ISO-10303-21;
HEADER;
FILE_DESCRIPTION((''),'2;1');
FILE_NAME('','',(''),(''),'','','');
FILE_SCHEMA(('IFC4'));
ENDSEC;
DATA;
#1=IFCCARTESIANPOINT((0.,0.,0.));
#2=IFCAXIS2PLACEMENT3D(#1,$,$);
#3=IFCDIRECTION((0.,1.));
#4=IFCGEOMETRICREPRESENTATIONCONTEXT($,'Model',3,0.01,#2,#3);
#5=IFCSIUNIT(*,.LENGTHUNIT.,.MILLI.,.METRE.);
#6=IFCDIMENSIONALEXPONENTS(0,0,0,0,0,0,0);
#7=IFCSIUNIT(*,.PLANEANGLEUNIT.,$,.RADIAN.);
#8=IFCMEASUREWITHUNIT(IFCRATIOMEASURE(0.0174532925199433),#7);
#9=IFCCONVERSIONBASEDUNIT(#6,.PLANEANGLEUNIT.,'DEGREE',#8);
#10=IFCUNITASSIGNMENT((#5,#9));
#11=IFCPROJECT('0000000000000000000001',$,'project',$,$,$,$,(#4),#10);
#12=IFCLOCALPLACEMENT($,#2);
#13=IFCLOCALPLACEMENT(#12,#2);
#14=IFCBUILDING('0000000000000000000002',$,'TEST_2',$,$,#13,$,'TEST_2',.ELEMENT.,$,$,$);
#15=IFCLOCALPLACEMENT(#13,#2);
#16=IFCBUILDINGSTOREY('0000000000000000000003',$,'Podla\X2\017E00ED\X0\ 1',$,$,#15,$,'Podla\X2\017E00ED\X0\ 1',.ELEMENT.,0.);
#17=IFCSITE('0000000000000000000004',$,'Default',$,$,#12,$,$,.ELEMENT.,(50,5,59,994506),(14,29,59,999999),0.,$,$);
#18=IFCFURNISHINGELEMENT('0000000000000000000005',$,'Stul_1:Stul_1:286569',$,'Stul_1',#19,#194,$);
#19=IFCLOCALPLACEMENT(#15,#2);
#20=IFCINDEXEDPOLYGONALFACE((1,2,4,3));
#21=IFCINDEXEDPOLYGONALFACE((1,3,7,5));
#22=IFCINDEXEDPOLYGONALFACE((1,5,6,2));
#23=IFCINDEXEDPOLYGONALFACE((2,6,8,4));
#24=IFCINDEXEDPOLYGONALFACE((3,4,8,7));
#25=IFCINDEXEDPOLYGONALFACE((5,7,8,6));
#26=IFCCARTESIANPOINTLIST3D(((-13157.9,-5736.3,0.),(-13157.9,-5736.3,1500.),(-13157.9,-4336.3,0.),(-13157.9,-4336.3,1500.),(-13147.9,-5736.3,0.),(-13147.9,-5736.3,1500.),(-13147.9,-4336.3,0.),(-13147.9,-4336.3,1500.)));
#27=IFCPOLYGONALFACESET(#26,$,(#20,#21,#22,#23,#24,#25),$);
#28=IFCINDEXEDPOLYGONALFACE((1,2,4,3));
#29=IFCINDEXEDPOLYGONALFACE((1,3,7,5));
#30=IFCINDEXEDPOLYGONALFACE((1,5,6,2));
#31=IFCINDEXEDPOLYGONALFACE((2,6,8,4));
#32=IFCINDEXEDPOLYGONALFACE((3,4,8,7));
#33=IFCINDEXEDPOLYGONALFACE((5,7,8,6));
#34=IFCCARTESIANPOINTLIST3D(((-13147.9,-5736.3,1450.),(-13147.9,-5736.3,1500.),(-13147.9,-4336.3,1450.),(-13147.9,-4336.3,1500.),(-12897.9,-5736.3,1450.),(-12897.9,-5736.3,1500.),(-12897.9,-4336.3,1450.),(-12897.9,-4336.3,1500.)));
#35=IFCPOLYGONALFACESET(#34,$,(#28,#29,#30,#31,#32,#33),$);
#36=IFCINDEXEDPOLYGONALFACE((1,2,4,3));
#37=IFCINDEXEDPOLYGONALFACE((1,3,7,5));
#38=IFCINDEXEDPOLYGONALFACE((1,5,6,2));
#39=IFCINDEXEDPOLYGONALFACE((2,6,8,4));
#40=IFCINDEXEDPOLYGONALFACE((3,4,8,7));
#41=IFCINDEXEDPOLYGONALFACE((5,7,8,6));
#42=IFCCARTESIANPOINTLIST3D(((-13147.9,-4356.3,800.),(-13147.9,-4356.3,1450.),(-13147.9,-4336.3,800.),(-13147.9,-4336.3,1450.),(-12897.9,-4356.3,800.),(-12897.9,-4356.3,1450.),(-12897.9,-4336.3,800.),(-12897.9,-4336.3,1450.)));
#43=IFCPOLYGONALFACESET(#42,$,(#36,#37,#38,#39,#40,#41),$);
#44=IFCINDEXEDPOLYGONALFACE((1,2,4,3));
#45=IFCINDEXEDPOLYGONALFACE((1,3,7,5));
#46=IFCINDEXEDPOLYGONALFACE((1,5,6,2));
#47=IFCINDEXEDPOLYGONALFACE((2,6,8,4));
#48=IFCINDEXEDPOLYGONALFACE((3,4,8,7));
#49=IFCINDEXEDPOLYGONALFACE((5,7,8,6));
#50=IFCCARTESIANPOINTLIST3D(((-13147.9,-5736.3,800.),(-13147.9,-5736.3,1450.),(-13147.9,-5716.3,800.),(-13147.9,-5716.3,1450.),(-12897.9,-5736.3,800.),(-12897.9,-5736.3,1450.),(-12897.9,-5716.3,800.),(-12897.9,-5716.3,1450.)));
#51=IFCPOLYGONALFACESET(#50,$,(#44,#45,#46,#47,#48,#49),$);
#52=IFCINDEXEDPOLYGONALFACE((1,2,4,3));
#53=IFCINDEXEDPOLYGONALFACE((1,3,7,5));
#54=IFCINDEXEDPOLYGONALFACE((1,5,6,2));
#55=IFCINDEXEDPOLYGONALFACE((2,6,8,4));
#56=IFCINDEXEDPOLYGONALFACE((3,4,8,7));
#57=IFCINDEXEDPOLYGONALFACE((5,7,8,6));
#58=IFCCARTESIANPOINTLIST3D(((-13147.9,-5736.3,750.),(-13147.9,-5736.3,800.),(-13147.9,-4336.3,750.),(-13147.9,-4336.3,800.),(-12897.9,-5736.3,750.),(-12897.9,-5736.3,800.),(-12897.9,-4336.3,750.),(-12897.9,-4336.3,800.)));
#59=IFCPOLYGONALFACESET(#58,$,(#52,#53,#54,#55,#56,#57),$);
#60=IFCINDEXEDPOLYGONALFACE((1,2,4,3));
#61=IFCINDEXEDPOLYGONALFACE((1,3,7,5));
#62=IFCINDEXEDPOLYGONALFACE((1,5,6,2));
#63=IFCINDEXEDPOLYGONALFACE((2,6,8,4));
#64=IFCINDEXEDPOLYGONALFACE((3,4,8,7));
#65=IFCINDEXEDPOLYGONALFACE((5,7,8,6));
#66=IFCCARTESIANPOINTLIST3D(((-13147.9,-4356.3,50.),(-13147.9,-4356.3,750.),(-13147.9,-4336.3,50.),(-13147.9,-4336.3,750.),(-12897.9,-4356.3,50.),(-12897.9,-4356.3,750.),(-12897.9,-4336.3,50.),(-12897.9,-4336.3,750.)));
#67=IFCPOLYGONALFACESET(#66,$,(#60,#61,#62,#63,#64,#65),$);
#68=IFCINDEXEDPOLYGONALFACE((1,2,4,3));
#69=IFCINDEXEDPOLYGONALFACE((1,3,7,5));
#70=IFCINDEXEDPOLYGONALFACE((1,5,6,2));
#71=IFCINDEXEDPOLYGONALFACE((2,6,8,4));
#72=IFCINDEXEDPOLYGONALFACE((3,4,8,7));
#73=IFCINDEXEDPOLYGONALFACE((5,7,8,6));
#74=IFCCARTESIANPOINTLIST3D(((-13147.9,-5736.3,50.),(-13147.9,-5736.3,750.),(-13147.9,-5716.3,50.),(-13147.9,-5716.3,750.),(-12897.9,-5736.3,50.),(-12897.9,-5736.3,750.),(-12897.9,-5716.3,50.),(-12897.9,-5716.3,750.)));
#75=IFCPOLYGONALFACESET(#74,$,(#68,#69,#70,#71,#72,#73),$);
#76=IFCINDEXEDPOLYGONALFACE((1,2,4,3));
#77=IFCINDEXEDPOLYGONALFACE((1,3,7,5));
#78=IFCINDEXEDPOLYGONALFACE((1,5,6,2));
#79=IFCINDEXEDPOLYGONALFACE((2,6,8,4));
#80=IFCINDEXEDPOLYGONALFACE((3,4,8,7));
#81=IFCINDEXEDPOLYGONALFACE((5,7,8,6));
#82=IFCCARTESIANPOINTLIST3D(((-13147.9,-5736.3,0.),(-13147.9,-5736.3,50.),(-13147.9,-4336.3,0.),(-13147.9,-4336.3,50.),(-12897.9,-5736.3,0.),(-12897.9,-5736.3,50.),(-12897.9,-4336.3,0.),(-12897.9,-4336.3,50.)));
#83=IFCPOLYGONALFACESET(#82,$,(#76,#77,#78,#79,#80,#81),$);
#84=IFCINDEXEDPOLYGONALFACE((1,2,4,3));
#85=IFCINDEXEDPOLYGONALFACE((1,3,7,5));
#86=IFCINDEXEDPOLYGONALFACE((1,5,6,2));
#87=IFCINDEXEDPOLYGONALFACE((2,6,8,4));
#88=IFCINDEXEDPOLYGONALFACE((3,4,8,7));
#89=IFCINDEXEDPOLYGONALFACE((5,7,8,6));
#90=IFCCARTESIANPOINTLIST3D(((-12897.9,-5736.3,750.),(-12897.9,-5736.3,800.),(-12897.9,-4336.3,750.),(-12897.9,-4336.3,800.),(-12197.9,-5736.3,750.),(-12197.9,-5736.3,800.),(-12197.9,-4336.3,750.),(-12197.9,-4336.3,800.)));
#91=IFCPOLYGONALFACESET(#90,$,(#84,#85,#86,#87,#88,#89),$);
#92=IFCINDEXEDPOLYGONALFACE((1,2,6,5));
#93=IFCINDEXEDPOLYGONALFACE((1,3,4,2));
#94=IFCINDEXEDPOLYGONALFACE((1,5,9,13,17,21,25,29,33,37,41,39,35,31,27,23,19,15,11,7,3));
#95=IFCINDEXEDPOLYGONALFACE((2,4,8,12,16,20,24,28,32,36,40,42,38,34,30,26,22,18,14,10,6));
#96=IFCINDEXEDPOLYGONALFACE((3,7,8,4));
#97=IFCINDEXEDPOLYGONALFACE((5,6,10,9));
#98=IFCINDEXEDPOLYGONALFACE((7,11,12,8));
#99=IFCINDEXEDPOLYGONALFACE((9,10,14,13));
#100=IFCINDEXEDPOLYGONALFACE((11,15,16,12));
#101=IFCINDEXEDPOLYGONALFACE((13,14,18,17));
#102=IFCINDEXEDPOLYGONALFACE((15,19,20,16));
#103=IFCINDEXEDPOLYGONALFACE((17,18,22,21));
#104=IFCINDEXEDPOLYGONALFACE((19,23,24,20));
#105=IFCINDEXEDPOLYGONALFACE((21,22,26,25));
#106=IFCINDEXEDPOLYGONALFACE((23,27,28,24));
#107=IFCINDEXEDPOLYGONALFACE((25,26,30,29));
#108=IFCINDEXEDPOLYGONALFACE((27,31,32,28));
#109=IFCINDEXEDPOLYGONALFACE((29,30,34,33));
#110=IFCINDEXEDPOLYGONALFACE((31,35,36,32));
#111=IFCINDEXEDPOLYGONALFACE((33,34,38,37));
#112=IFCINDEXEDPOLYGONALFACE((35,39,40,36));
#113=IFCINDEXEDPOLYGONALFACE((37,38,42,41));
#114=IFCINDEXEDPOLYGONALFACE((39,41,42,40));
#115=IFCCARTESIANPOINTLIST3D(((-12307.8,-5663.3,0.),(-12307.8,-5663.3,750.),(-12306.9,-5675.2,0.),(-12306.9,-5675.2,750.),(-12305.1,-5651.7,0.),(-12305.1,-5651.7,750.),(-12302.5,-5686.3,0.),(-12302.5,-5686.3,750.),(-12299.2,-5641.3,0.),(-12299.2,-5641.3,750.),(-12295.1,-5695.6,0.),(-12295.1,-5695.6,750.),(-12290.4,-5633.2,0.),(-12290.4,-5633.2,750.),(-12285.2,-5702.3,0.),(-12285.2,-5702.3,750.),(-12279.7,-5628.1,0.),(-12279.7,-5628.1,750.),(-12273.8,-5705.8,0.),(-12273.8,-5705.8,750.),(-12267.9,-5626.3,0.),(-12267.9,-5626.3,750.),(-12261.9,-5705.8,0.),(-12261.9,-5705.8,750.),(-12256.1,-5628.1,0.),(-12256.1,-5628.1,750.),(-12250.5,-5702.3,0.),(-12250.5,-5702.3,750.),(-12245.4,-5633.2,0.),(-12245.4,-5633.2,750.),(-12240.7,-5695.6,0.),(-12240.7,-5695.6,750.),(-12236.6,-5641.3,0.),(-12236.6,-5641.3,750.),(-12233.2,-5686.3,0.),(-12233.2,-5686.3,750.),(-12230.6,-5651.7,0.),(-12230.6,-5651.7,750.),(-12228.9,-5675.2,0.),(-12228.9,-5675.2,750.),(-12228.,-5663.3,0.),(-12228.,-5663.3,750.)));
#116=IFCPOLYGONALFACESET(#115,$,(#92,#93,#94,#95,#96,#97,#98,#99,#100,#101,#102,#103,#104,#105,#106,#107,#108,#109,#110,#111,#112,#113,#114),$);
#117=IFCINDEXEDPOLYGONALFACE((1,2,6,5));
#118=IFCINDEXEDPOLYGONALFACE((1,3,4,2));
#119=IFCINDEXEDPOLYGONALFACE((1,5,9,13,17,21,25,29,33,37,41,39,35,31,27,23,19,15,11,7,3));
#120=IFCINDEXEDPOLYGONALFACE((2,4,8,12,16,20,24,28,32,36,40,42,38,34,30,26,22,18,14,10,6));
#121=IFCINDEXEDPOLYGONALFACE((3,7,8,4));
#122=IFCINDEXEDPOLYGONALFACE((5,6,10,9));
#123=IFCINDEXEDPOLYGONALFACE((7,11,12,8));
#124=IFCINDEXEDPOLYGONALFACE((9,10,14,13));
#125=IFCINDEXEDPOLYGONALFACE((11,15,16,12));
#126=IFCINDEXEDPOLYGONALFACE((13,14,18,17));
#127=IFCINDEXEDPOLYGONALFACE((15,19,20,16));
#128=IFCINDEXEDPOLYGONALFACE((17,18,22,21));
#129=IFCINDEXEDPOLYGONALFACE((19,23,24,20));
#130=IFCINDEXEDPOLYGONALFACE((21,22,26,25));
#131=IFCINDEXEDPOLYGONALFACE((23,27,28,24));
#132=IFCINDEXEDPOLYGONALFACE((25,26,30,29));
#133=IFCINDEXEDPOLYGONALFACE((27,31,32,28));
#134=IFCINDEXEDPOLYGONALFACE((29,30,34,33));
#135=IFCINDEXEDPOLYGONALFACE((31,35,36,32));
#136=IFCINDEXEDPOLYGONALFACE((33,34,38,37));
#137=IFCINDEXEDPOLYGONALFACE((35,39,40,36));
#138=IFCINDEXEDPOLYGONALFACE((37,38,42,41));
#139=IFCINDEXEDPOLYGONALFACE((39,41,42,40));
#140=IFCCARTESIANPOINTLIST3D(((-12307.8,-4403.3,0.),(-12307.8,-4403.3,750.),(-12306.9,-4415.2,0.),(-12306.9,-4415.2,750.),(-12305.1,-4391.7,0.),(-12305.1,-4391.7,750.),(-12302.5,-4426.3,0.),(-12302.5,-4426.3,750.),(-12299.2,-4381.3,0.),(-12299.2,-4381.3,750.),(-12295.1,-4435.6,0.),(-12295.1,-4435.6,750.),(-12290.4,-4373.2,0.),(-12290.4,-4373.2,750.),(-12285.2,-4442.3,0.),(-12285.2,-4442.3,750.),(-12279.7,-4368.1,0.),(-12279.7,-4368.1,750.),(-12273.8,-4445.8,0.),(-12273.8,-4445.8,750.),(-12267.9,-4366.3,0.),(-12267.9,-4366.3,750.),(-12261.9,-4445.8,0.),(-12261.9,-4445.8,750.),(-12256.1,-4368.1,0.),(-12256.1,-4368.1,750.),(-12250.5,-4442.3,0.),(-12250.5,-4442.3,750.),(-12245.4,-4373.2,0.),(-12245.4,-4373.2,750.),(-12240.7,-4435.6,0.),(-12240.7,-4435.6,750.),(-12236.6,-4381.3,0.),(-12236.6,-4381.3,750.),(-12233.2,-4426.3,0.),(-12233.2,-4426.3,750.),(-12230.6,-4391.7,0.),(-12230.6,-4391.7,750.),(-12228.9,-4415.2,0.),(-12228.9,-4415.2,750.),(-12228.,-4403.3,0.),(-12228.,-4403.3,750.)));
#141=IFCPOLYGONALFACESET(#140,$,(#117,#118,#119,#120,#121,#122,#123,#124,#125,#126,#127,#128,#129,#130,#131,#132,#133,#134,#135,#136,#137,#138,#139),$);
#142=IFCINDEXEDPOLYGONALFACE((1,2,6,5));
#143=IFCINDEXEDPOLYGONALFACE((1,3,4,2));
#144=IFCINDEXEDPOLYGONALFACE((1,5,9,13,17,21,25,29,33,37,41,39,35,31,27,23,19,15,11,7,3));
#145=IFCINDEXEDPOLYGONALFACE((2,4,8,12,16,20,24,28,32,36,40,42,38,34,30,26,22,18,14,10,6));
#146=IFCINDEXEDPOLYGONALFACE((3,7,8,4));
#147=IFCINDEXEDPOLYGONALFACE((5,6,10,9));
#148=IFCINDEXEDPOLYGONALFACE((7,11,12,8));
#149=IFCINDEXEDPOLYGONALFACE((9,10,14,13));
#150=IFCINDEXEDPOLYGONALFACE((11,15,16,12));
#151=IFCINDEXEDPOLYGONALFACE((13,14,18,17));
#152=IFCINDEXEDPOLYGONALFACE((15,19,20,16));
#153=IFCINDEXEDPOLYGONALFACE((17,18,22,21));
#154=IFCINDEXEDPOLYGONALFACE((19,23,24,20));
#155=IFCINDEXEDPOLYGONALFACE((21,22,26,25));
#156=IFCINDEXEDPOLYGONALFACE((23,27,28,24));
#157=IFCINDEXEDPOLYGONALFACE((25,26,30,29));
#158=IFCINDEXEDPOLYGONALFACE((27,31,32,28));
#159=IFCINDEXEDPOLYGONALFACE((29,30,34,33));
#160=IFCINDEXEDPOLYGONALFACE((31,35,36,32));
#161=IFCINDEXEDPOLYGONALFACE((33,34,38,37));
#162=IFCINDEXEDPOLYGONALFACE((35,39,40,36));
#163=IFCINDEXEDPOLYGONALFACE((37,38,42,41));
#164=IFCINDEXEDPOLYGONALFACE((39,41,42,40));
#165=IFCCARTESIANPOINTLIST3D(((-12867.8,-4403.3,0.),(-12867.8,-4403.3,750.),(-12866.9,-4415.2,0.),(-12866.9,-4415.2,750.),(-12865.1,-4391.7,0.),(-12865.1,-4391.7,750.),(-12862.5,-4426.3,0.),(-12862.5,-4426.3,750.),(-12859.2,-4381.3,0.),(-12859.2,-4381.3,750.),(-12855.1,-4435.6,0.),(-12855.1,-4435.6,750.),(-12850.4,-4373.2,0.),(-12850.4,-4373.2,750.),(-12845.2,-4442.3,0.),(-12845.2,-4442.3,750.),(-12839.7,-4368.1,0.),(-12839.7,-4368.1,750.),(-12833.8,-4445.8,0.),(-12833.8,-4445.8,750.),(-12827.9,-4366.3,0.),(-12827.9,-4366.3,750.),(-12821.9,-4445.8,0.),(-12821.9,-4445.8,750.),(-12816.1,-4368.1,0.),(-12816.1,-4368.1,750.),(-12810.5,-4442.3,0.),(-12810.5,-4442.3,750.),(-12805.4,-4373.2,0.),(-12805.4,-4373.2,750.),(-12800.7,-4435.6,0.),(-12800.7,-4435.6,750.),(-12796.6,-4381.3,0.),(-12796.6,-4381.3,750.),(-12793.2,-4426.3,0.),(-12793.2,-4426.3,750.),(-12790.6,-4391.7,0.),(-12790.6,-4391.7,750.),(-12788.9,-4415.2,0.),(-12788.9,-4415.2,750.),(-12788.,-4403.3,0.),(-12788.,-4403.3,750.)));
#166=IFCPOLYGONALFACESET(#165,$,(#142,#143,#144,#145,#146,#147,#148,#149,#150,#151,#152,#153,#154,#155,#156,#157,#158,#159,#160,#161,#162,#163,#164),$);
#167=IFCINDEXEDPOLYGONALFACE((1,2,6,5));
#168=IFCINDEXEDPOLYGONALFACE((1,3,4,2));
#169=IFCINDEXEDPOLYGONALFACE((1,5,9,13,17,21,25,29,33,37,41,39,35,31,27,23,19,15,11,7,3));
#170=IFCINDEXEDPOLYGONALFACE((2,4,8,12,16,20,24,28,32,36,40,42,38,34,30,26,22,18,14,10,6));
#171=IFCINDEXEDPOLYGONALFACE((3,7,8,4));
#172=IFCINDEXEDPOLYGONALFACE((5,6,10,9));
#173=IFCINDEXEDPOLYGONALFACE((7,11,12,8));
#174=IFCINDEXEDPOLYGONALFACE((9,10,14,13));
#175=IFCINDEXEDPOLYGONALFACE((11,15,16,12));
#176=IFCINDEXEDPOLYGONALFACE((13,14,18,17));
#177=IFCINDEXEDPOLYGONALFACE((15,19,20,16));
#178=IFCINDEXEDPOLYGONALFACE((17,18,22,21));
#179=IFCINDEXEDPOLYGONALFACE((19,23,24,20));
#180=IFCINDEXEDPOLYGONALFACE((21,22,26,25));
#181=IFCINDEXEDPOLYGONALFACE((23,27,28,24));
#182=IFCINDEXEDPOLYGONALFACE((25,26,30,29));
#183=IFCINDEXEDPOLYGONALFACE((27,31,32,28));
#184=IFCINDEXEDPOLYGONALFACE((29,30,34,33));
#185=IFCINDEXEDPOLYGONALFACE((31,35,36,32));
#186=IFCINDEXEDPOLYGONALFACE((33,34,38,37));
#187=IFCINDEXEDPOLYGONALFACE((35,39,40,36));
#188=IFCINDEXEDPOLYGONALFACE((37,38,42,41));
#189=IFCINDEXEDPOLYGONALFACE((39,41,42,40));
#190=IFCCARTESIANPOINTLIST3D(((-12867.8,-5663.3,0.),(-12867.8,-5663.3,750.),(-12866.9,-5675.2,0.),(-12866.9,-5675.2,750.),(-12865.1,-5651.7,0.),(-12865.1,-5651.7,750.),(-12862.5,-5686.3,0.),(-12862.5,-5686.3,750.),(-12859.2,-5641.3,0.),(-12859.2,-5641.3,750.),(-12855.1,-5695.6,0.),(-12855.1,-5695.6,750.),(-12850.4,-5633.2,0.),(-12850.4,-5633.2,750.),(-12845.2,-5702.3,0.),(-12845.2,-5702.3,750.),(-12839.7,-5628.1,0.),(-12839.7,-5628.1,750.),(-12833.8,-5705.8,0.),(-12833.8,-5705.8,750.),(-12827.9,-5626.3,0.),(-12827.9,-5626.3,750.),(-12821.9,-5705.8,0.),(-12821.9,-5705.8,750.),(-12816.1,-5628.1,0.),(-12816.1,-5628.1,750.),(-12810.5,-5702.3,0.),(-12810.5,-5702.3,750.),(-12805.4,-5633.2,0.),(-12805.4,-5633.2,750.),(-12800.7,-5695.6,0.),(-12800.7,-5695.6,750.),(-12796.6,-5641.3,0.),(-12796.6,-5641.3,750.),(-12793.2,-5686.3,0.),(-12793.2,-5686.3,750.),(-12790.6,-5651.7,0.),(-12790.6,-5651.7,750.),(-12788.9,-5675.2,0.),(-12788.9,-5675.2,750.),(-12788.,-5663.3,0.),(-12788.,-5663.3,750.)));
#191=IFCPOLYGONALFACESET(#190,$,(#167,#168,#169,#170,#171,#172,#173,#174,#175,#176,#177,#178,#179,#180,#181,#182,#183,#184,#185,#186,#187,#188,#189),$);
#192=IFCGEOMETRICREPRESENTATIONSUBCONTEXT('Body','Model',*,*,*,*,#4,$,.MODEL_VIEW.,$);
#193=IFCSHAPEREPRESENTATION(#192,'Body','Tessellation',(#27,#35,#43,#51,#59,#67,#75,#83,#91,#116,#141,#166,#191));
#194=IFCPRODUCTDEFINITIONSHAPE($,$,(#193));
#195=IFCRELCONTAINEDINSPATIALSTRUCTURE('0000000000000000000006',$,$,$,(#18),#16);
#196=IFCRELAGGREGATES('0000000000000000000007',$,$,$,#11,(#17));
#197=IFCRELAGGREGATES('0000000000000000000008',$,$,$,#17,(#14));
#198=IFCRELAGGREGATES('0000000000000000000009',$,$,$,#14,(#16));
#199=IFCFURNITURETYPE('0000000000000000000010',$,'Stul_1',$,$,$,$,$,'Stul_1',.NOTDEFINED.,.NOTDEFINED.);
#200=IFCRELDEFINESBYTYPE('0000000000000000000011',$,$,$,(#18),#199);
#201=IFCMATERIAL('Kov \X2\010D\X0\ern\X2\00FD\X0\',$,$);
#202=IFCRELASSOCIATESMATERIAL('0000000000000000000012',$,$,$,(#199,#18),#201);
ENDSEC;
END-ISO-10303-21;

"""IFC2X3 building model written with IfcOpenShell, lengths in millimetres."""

from ifc_helpers import new_model, entity, si_unit, converted_unit, direction, frame, frame_2d, origin, origin_2d_with_axis, place, context, subcontext, project, spatial, rectangle, circle, extrude, source, transform, mapped, material, type_object, type_shapes, element, save


model = new_model("IFC2X3")

# Units and contexts
model_context = context("Model", 3, precision=0.01, world=origin(), true_north=direction((0.0, 1.0)))
body_context = subcontext(model_context, "Body", "Model", "MODEL_VIEW")
ifc_project = project(units=[si_unit("LENGTHUNIT", "METRE", prefix="MILLI"), converted_unit("PLANEANGLEUNIT", "DEGREE", entity("IfcRatioMeasure", 0.0174532925199433), si_unit("PLANEANGLEUNIT", "RADIAN"), dimensions=[0, 0, 0, 0, 0, 0, 0])], contexts=[model_context])

# Site, building, storey
site_placement = place(None, origin())
site = spatial("IfcSite", under=ifc_project, at=site_placement, Name="Default", CompositionType="ELEMENT", RefLatitude=(50, 5, 59, 994506), RefLongitude=(14, 29, 59, 999999), RefElevation=0.0)
building_placement = place(site_placement, origin())
building = spatial("IfcBuilding", under=site, at=building_placement, Name="TEST_2", LongName="TEST_2", CompositionType="ELEMENT")
storey_placement = place(building_placement, origin())
storey = spatial("IfcBuildingStorey", under=building, at=storey_placement, Name="Podlaží 1", LongName="Podlaží 1", CompositionType="ELEMENT", Elevation=0.0)

# Furnishing element
ifc_material_1 = material(Name="Kov černý")
furniture_type = type_object("IfcFurnitureType", Name="Stul_1", ElementType="Stul_1", material=ifc_material_1)
shared_shape_1 = source(origin(), body_context, "Body", "SweptSolid", [
    extrude(rectangle(XDim=1400.0, YDim=10.0, at=origin_2d_with_axis()), frame((0.0, 605.0, 0.0), z_axis=(0.0, 0.0, 1.0), x_axis=(-1.0, 0.0, 0.0)), (0.0, 0.0, 1.0), 1500.0),
    extrude(rectangle(XDim=1400.0, YDim=250.0, at=frame_2d((0.0, 0.0), x_axis=(1.0, 0.0))), frame((0.0, 475.0, 1450.0), z_axis=(0.0, 0.0, 1.0), x_axis=(-1.0, 0.0, 0.0)), (0.0, 0.0, 1.0), 50.0),
    extrude(rectangle(XDim=20.0, YDim=250.0, at=origin_2d_with_axis()), frame((690.0, 475.0, 800.0), z_axis=(0.0, 0.0, 1.0), x_axis=(-1.0, 0.0, 0.0)), (0.0, 0.0, 1.0), 650.0),
    extrude(rectangle(XDim=20.0, YDim=250.0, at=frame_2d((0.0, 0.0), x_axis=(1.0, 0.0))), frame((-690.0, 475.0, 800.0), z_axis=(0.0, 0.0, 1.0), x_axis=(-1.0, 0.0, 0.0)), (0.0, 0.0, 1.0), 650.0),
    extrude(rectangle(XDim=1400.0, YDim=250.0, at=origin_2d_with_axis()), frame((0.0, 475.0, 750.0), z_axis=(0.0, 0.0, 1.0), x_axis=(-1.0, 0.0, 0.0)), (0.0, 0.0, 1.0), 50.0),
    extrude(rectangle(XDim=20.0, YDim=250.0, at=origin_2d_with_axis()), frame((690.0, 475.0, 50.0), z_axis=(0.0, 0.0, 1.0), x_axis=(-1.0, 0.0, 0.0)), (0.0, 0.0, 1.0), 700.0),
    extrude(rectangle(XDim=20.0, YDim=250.0, at=frame_2d((0.0, 0.0), x_axis=(1.0, 0.0))), frame((-690.0, 475.0, 50.0), z_axis=(0.0, 0.0, 1.0), x_axis=(-1.0, 0.0, 0.0)), (0.0, 0.0, 1.0), 700.0),
    extrude(rectangle(XDim=1400.0, YDim=250.0, at=origin_2d_with_axis()), frame((0.0, 475.0, 0.0), z_axis=(0.0, 0.0, 1.0), x_axis=(-1.0, 0.0, 0.0)), (0.0, 0.0, 1.0), 50.0),
    extrude(rectangle(XDim=1400.0, YDim=700.0, at=origin_2d_with_axis()), frame((0.0, 0.0, 750.0), z_axis=(0.0, 0.0, 1.0), x_axis=(-1.0, 0.0, 0.0)), (0.0, 0.0, 1.0), 50.0),
    extrude(circle(Radius=40.0, at=frame_2d((0.0, 0.0), x_axis=(1.0, 0.0))), frame((-630.0, -280.0, 0.0)), (0.0, 0.0, 1.0), 750.0),
    extrude(circle(Radius=40.0, at=frame_2d((0.0, 0.0), x_axis=(1.0, 0.0))), frame((630.0, -280.0, 0.0)), (0.0, 0.0, 1.0), 750.0),
    extrude(circle(Radius=40.0, at=frame_2d((0.0, 0.0), x_axis=(1.0, 0.0))), frame((630.0, 280.0, 0.0)), (0.0, 0.0, 1.0), 750.0),
    extrude(circle(Radius=40.0, at=frame_2d((0.0, 0.0), x_axis=(1.0, 0.0))), frame((-630.0, 280.0, 0.0)), (0.0, 0.0, 1.0), 750.0),
])
type_shapes(furniture_type, [shared_shape_1])
for number, where, z_axis, x_axis, name in (
    (1, (-12547.9, -5036.3, 0.0), (0.0, 0.0, 1.0), (0.0, 1.0, 0.0), "Stul_1:Stul_1:286569"),
):
    element("IfcFurnishingElement", number, at=place(storey_placement, frame(where, z_axis=z_axis, x_axis=x_axis)), inside=storey, type_object=furniture_type, material=ifc_material_1, Name=name, ObjectType="Stul_1", context=body_context, shape_type="MappedRepresentation", body=[
        mapped(shared_shape_1, transform((0.0, 0.0, 0.0), scale=1.0)),
    ])

save(model, "model.ifc")
